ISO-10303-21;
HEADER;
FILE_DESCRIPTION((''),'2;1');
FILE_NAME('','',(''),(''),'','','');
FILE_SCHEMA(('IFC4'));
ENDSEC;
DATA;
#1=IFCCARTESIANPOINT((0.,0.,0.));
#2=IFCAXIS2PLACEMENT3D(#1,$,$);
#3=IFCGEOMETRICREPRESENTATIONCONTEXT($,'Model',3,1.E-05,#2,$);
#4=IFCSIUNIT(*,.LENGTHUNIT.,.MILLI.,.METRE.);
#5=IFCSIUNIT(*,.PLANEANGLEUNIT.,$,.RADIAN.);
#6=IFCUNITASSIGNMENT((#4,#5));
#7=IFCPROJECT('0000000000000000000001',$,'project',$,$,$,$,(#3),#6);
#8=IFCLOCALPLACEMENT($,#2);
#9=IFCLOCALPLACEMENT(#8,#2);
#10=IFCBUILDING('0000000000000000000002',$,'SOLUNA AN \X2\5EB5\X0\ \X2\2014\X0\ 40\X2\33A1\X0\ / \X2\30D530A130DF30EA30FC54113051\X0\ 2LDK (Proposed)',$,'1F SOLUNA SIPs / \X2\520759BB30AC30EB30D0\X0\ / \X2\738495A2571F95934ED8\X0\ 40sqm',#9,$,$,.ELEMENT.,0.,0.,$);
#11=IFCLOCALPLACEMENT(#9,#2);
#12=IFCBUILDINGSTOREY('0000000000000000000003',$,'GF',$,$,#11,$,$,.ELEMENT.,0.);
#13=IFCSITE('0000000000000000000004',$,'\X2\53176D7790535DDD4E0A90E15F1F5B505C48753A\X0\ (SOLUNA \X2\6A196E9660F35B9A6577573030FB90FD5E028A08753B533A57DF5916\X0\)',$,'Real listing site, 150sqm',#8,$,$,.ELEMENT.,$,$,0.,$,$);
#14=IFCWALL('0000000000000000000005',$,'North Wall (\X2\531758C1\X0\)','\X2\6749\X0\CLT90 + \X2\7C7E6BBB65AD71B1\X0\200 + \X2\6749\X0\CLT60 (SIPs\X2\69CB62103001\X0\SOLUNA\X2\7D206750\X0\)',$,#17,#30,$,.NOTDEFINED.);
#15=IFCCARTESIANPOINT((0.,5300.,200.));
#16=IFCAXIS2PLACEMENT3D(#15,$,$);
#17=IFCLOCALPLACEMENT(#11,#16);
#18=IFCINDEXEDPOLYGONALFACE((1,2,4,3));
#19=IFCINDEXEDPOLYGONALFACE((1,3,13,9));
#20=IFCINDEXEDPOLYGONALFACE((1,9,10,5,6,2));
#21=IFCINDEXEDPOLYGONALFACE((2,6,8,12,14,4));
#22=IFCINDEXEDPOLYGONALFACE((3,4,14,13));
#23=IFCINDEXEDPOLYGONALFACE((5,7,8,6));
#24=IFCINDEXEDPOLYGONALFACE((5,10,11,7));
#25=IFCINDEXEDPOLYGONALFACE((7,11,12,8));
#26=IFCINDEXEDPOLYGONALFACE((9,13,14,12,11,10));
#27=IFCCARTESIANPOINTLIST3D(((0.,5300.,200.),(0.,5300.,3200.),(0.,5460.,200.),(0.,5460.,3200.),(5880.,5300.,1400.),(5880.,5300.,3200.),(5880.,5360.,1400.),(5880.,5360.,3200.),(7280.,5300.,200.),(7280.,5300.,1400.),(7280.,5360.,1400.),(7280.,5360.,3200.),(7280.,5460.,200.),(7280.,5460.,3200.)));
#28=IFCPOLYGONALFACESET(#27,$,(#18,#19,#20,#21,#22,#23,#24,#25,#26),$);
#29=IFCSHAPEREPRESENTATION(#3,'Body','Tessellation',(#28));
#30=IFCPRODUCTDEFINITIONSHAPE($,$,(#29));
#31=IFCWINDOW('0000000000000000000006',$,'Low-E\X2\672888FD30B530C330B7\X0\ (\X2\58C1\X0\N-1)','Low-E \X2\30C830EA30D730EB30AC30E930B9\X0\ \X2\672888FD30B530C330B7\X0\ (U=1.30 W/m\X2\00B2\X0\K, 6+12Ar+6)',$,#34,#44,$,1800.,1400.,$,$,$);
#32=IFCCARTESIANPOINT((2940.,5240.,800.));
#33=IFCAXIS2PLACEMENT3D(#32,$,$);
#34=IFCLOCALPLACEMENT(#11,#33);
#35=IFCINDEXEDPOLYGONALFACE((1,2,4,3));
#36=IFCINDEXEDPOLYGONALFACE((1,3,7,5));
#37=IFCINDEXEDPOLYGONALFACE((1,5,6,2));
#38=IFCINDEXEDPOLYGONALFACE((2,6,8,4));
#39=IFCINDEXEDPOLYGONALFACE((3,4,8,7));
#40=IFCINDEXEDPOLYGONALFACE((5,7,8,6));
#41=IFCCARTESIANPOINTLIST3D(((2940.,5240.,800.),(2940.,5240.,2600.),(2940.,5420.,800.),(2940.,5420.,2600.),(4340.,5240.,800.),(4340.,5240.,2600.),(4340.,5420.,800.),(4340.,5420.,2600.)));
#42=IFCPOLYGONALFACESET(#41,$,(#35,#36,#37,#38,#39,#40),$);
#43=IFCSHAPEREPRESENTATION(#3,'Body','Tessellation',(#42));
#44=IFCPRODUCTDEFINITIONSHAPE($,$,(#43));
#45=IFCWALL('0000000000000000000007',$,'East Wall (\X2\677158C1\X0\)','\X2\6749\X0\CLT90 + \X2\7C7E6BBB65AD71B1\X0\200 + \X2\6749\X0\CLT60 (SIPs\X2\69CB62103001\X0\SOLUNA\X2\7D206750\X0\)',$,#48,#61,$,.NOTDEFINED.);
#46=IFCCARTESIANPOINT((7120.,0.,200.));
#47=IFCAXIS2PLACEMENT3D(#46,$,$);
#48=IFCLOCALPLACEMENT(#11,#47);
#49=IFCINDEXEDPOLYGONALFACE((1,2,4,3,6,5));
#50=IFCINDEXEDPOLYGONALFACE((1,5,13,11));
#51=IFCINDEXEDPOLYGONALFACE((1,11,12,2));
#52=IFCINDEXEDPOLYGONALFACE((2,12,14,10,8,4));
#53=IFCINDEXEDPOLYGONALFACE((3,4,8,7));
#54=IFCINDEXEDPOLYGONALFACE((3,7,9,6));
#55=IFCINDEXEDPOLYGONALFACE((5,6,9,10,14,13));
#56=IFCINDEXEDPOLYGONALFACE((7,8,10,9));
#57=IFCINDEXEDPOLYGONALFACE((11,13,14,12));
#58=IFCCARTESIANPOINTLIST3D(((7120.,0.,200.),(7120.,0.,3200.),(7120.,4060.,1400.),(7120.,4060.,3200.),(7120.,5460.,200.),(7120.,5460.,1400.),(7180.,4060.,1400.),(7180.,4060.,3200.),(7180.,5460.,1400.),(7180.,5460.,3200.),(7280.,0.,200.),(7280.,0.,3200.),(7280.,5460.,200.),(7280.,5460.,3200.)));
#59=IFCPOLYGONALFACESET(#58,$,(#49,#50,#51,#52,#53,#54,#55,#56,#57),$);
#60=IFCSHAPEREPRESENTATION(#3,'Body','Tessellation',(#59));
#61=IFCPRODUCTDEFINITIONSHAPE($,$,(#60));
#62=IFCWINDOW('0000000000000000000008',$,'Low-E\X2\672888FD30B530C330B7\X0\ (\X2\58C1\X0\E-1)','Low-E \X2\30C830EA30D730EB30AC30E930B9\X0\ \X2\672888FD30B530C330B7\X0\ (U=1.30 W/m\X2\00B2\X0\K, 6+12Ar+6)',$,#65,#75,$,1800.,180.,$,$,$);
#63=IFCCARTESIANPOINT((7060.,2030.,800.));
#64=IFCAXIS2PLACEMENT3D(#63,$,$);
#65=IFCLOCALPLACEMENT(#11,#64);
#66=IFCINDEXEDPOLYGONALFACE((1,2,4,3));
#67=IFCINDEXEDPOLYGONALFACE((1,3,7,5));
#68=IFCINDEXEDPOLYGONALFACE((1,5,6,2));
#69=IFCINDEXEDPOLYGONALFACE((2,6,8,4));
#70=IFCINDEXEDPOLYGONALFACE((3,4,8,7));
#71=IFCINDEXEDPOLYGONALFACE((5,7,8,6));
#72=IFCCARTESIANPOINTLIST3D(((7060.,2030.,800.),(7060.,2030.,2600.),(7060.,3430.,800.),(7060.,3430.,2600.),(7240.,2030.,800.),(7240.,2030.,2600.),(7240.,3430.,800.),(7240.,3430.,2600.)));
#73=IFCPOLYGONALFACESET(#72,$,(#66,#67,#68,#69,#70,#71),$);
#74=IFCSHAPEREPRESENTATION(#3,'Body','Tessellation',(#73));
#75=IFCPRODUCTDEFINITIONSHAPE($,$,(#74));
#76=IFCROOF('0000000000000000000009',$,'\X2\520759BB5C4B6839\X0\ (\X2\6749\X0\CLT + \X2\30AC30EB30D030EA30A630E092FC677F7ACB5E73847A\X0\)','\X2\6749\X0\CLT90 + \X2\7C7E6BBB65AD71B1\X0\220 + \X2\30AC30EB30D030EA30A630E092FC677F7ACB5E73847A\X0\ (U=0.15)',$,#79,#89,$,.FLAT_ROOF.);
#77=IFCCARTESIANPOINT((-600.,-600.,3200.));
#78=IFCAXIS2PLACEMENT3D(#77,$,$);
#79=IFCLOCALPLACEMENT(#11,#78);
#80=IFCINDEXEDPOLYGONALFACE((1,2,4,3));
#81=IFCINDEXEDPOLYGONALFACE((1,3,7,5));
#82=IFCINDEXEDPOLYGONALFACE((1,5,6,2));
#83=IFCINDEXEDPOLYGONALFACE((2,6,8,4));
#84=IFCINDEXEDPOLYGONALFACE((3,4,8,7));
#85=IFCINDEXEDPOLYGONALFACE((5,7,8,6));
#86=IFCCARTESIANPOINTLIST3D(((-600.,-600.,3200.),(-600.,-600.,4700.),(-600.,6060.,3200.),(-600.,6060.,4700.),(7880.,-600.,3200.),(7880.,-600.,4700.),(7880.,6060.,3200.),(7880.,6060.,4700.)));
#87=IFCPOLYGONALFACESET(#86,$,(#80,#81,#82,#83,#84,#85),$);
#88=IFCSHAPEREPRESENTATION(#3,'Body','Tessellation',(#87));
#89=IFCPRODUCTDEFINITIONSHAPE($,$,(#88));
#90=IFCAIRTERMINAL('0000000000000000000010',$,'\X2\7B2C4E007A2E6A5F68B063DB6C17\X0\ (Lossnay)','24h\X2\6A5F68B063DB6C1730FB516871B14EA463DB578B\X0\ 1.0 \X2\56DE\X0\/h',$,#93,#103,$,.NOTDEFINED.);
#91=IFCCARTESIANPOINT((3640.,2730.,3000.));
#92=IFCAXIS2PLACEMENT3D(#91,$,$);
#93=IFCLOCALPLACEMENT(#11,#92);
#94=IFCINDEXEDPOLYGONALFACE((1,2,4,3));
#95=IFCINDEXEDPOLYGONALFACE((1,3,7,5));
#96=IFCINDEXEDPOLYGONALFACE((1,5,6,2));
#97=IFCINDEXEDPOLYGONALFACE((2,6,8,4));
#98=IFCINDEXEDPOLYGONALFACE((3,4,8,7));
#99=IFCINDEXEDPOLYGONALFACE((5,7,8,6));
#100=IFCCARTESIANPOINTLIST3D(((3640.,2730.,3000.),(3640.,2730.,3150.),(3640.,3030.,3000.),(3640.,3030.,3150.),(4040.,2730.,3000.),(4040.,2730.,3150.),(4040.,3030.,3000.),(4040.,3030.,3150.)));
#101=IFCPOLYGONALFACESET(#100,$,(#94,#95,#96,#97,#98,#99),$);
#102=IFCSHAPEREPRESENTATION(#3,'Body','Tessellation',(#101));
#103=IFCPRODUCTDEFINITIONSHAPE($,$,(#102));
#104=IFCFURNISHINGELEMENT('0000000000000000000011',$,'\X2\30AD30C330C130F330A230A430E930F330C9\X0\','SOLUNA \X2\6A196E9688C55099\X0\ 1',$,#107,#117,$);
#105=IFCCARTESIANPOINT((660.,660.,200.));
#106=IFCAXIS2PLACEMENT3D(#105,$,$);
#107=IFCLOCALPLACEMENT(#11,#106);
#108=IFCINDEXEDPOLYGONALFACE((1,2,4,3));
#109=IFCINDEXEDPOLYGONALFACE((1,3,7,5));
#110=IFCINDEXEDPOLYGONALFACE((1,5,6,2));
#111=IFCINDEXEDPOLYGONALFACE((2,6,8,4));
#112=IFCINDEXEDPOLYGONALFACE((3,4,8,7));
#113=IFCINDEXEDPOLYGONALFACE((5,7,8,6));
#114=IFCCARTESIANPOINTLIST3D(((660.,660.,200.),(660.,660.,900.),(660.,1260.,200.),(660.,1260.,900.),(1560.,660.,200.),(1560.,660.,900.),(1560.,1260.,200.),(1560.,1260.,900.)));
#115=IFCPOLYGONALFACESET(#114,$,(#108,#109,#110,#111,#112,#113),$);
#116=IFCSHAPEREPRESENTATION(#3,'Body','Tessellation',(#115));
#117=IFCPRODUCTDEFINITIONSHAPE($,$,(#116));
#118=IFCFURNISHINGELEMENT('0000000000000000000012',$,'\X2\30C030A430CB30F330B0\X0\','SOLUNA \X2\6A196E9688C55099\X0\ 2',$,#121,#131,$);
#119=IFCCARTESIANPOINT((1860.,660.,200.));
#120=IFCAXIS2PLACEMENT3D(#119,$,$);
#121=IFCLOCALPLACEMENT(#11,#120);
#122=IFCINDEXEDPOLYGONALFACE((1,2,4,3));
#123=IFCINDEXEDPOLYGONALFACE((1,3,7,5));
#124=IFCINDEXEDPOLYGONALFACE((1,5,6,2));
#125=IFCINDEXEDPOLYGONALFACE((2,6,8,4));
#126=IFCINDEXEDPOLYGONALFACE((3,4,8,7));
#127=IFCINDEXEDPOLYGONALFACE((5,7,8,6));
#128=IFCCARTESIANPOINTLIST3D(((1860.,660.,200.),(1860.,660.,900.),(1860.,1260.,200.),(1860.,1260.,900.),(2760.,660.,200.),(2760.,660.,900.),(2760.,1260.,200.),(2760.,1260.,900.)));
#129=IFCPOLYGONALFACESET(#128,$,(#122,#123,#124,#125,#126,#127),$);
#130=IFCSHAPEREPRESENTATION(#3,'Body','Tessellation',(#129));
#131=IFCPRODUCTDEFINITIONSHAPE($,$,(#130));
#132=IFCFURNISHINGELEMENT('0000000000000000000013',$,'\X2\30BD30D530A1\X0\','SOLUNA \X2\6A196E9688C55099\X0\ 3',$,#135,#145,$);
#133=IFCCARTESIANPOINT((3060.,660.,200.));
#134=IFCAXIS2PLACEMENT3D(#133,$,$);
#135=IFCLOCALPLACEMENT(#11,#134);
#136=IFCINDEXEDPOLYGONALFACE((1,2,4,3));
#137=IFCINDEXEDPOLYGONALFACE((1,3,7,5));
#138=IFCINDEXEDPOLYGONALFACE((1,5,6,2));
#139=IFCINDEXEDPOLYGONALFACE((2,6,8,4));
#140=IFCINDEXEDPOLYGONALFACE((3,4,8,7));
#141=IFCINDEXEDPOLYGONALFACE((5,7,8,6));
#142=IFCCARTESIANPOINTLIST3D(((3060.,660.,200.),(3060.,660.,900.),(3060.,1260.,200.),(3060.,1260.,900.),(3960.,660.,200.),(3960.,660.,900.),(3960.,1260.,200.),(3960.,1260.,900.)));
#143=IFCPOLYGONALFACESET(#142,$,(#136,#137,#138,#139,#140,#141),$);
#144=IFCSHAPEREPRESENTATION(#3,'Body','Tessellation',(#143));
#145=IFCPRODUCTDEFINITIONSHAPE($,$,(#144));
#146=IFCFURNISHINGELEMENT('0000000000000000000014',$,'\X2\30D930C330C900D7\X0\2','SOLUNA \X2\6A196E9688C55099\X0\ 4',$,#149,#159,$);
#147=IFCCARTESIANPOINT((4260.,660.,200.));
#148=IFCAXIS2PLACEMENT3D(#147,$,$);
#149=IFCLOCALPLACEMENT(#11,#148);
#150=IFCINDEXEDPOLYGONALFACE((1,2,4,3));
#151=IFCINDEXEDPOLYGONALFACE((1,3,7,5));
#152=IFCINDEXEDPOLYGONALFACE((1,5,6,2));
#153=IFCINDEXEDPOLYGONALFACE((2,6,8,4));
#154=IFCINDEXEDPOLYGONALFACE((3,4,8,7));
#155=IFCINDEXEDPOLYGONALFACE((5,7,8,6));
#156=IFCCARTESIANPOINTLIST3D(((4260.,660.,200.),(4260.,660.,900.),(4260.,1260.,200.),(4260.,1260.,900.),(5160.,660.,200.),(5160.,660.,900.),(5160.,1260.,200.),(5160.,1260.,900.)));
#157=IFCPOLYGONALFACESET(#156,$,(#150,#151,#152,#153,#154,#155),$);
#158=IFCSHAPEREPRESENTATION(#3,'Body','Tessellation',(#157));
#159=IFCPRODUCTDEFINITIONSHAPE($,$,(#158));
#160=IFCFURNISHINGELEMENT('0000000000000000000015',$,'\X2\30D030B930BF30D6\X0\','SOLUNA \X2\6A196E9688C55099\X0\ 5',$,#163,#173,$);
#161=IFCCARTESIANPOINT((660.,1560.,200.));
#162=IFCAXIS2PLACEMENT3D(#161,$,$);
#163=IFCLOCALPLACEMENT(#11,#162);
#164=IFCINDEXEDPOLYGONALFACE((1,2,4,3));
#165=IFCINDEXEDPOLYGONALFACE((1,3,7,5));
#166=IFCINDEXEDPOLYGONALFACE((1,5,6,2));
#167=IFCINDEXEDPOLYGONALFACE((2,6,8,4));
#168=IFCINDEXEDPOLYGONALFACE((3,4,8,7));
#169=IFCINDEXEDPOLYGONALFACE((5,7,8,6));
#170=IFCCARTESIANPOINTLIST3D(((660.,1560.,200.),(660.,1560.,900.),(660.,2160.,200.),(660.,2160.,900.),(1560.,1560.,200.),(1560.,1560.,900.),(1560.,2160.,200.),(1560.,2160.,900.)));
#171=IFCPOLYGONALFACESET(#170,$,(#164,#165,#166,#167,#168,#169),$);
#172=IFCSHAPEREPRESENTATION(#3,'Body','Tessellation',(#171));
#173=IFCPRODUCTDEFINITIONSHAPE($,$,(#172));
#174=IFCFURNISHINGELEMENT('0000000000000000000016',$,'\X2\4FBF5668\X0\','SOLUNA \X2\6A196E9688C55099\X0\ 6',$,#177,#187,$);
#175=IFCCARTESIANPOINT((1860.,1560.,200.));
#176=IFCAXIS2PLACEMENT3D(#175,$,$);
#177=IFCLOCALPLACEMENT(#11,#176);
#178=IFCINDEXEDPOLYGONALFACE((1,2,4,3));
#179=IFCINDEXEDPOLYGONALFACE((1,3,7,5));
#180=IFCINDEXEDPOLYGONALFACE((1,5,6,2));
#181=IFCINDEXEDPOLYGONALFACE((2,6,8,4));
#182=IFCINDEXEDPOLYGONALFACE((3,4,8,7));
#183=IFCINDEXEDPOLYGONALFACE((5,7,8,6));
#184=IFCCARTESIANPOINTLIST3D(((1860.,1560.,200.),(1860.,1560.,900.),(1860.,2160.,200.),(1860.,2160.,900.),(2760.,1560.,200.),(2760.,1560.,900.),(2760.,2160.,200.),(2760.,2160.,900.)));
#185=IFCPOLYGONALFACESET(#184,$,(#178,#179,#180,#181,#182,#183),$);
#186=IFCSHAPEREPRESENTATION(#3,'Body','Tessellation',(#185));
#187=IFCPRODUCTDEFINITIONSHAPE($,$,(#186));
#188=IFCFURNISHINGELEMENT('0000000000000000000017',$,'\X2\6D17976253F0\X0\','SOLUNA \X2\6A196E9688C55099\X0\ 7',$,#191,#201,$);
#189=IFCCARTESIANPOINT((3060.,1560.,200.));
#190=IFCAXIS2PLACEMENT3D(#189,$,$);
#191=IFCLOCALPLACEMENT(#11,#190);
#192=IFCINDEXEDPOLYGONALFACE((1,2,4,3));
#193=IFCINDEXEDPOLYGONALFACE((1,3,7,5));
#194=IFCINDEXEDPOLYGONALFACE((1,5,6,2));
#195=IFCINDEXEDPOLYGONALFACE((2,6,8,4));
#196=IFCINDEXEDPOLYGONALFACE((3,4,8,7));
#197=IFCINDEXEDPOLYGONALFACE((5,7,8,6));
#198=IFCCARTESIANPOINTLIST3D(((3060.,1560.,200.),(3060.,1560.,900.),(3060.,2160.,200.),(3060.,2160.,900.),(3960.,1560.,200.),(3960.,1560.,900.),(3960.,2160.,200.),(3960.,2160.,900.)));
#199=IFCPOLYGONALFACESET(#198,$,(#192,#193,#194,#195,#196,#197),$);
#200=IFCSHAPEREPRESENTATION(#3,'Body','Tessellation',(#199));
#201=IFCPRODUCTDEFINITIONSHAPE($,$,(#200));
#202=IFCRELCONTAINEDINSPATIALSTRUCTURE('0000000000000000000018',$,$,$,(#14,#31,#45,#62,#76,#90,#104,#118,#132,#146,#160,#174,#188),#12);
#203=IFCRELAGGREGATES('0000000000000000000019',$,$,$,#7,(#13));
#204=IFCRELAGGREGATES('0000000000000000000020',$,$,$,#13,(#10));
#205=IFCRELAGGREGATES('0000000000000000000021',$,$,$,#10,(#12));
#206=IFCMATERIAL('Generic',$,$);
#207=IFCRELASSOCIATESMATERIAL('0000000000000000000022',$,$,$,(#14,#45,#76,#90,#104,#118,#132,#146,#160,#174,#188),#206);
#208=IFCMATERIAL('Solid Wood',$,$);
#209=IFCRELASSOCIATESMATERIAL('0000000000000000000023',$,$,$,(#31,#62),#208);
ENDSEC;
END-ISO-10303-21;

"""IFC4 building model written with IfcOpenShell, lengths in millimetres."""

from ifc_helpers import new_model, si_unit, frame, frame_2d, origin, place, context, project, spatial, rectangle, extrude, material, element, fill, save


model = new_model("IFC4")

# Units and contexts
model_context = context("Model", 3, precision=1e-05, world=origin())
ifc_project = project(units=[si_unit("LENGTHUNIT", "METRE", prefix="MILLI"), si_unit("PLANEANGLEUNIT", "RADIAN")], contexts=[model_context])

# Site, building, storey
site_placement = place(None, origin())
site = spatial("IfcSite", under=ifc_project, at=site_placement, Name="北海道川上郡弟子屈町 (SOLUNA 標準想定敷地・都市計画区域外)", ObjectType="Real listing site, 150sqm", CompositionType="ELEMENT", RefElevation=0.0)
building_placement = place(site_placement, origin())
building = spatial("IfcBuilding", under=site, at=building_placement, Name="SOLUNA AN 庵 — 40㎡ / ファミリー向け 2LDK (Proposed)", ObjectType="1F SOLUNA SIPs / 切妻ガルバ / 玄関土間付 40sqm", CompositionType="ELEMENT", ElevationOfRefHeight=0.0, ElevationOfTerrain=0.0)
storey_placement = place(building_placement, origin())
storey = spatial("IfcBuildingStorey", under=building, at=storey_placement, Name="GF", CompositionType="ELEMENT", Elevation=0.0)

# Shared definitions
ifc_material_1 = material(Name="Generic")

# Shared definitions
ifc_material_2 = material(Name="Solid Wood")

# Walls, openings, windows
wall_1_placement = place(storey_placement, frame((0.0, 5300.0, 200.0)))
wall_1 = element("IfcWall", 1, at=wall_1_placement, inside=storey, material=ifc_material_1, Name="North Wall (北壁)", Description="杉CLT90 + 籾殻断熱200 + 杉CLT60 (SIPs構成、SOLUNA素材)", PredefinedType="NOTDEFINED", context=model_context, shape_type="SweptSolid", body=[
    extrude(rectangle(XDim=7280.0, YDim=160.0, at=frame_2d((3640.0, 80.0))), frame((0.0, 5300.0, 200.0)), (0.0, 0.0, 1.0), 3000.0),
])
opening_1_placement = place(storey_placement, frame((2940.0, 5240.0, 800.0)))
opening_1 = element("IfcOpeningElement", 2, at=opening_1_placement, cuts=wall_1, PredefinedType="NOTDEFINED", context=model_context, shape_type="SweptSolid", body=[
    extrude(rectangle(XDim=1400.0, YDim=180.0, at=frame_2d((700.0, 90.0))), frame((2940.0, 5240.0, 800.0)), (0.0, 0.0, 1.0), 1800.0),
])
window_1_placement = place(storey_placement, frame((2940.0, 5240.0, 800.0)))
window_1 = element("IfcWindow", 3, at=window_1_placement, inside=storey, material=ifc_material_2, Name="Low-E木製サッシ (壁N-1)", Description="Low-E トリプルガラス 木製サッシ (U=1.30 W/m²K, 6+12Ar+6)", OverallHeight=1800.0, OverallWidth=1400.0, context=model_context, shape_type="SweptSolid", body=[
    extrude(rectangle(XDim=1400.0, YDim=180.0, at=frame_2d((700.0, 90.0))), frame((2940.0, 5240.0, 800.0)), (0.0, 0.0, 1.0), 1800.0),
])
fill(opening_1, window_1)
wall_2_placement = place(storey_placement, frame((7120.0, 0.0, 200.0)))
wall_2 = element("IfcWall", 4, at=wall_2_placement, inside=storey, material=ifc_material_1, Name="East Wall (東壁)", Description="杉CLT90 + 籾殻断熱200 + 杉CLT60 (SIPs構成、SOLUNA素材)", PredefinedType="NOTDEFINED", context=model_context, shape_type="SweptSolid", body=[
    extrude(rectangle(XDim=160.0, YDim=5460.0, at=frame_2d((80.0, 2730.0))), frame((7120.0, 0.0, 200.0)), (0.0, 0.0, 1.0), 3000.0),
])
opening_2_placement = place(storey_placement, frame((7060.0, 2030.0, 800.0)))
opening_2 = element("IfcOpeningElement", 5, at=opening_2_placement, cuts=wall_2, PredefinedType="NOTDEFINED", context=model_context, shape_type="SweptSolid", body=[
    extrude(rectangle(XDim=180.0, YDim=1400.0, at=frame_2d((90.0, 700.0))), frame((7060.0, 2030.0, 800.0)), (0.0, 0.0, 1.0), 1800.0),
])
window_2_placement = place(storey_placement, frame((7060.0, 2030.0, 800.0)))
window_2 = element("IfcWindow", 6, at=window_2_placement, inside=storey, material=ifc_material_2, Name="Low-E木製サッシ (壁E-1)", Description="Low-E トリプルガラス 木製サッシ (U=1.30 W/m²K, 6+12Ar+6)", OverallHeight=1800.0, OverallWidth=180.0, context=model_context, shape_type="SweptSolid", body=[
    extrude(rectangle(XDim=180.0, YDim=1400.0, at=frame_2d((90.0, 700.0))), frame((7060.0, 2030.0, 800.0)), (0.0, 0.0, 1.0), 1800.0),
])
fill(opening_2, window_2)

# Roof
roof_placement = place(storey_placement, frame((-600.0, -600.0, 3200.0)))
element("IfcRoof", 7, at=roof_placement, inside=storey, material=ifc_material_1, Name="切妻屋根 (杉CLT + ガルバリウム鋼板立平葺)", Description="杉CLT90 + 籾殻断熱220 + ガルバリウム鋼板立平葺 (U=0.15)", PredefinedType="FLAT_ROOF", context=model_context, shape_type="SweptSolid", body=[
    extrude(rectangle(XDim=8480.0, YDim=6660.0, at=frame_2d((4240.0, 3330.0))), frame((-600.0, -600.0, 3200.0)), (0.0, 0.0, 1.0), 1500.0),
])

# Air terminal
air_terminal_placement = place(storey_placement, frame((3640.0, 2730.0, 3000.0)))
element("IfcAirTerminal", 8, at=air_terminal_placement, inside=storey, material=ifc_material_1, Name="第一種機械換気 (Lossnay)", Description="24h機械換気・全熱交換型 1.0 回/h", PredefinedType="NOTDEFINED", context=model_context, shape_type="SweptSolid", body=[
    extrude(rectangle(XDim=400.0, YDim=300.0, at=frame_2d((200.0, 150.0))), frame((3640.0, 2730.0, 3000.0)), (0.0, 0.0, 1.0), 150.0),
])

# Furnishing elements
furnishing_1_placement = place(storey_placement, frame((660.0, 660.0, 200.0)))
element("IfcFurnishingElement", 9, at=furnishing_1_placement, inside=storey, material=ifc_material_1, Name="キッチンアイランド", Description="SOLUNA 標準装備 1", context=model_context, shape_type="SweptSolid", body=[
    extrude(rectangle(XDim=900.0, YDim=600.0, at=frame_2d((450.0, 300.0))), frame((660.0, 660.0, 200.0)), (0.0, 0.0, 1.0), 700.0),
])
furnishing_2_placement = place(storey_placement, frame((1860.0, 660.0, 200.0)))
element("IfcFurnishingElement", 10, at=furnishing_2_placement, inside=storey, material=ifc_material_1, Name="ダイニング", Description="SOLUNA 標準装備 2", context=model_context, shape_type="SweptSolid", body=[
    extrude(rectangle(XDim=900.0, YDim=600.0, at=frame_2d((450.0, 300.0))), frame((1860.0, 660.0, 200.0)), (0.0, 0.0, 1.0), 700.0),
])
furnishing_3_placement = place(storey_placement, frame((3060.0, 660.0, 200.0)))
element("IfcFurnishingElement", 11, at=furnishing_3_placement, inside=storey, material=ifc_material_1, Name="ソファ", Description="SOLUNA 標準装備 3", context=model_context, shape_type="SweptSolid", body=[
    extrude(rectangle(XDim=900.0, YDim=600.0, at=frame_2d((450.0, 300.0))), frame((3060.0, 660.0, 200.0)), (0.0, 0.0, 1.0), 700.0),
])
furnishing_4_placement = place(storey_placement, frame((4260.0, 660.0, 200.0)))
element("IfcFurnishingElement", 12, at=furnishing_4_placement, inside=storey, material=ifc_material_1, Name="ベッド×2", Description="SOLUNA 標準装備 4", context=model_context, shape_type="SweptSolid", body=[
    extrude(rectangle(XDim=900.0, YDim=600.0, at=frame_2d((450.0, 300.0))), frame((4260.0, 660.0, 200.0)), (0.0, 0.0, 1.0), 700.0),
])
furnishing_5_placement = place(storey_placement, frame((660.0, 1560.0, 200.0)))
element("IfcFurnishingElement", 13, at=furnishing_5_placement, inside=storey, material=ifc_material_1, Name="バスタブ", Description="SOLUNA 標準装備 5", context=model_context, shape_type="SweptSolid", body=[
    extrude(rectangle(XDim=900.0, YDim=600.0, at=frame_2d((450.0, 300.0))), frame((660.0, 1560.0, 200.0)), (0.0, 0.0, 1.0), 700.0),
])
furnishing_6_placement = place(storey_placement, frame((1860.0, 1560.0, 200.0)))
element("IfcFurnishingElement", 14, at=furnishing_6_placement, inside=storey, material=ifc_material_1, Name="便器", Description="SOLUNA 標準装備 6", context=model_context, shape_type="SweptSolid", body=[
    extrude(rectangle(XDim=900.0, YDim=600.0, at=frame_2d((450.0, 300.0))), frame((1860.0, 1560.0, 200.0)), (0.0, 0.0, 1.0), 700.0),
])
furnishing_7_placement = place(storey_placement, frame((3060.0, 1560.0, 200.0)))
element("IfcFurnishingElement", 15, at=furnishing_7_placement, inside=storey, material=ifc_material_1, Name="洗面台", Description="SOLUNA 標準装備 7", context=model_context, shape_type="SweptSolid", body=[
    extrude(rectangle(XDim=900.0, YDim=600.0, at=frame_2d((450.0, 300.0))), frame((3060.0, 1560.0, 200.0)), (0.0, 0.0, 1.0), 700.0),
])

save(model, "model.ifc")
